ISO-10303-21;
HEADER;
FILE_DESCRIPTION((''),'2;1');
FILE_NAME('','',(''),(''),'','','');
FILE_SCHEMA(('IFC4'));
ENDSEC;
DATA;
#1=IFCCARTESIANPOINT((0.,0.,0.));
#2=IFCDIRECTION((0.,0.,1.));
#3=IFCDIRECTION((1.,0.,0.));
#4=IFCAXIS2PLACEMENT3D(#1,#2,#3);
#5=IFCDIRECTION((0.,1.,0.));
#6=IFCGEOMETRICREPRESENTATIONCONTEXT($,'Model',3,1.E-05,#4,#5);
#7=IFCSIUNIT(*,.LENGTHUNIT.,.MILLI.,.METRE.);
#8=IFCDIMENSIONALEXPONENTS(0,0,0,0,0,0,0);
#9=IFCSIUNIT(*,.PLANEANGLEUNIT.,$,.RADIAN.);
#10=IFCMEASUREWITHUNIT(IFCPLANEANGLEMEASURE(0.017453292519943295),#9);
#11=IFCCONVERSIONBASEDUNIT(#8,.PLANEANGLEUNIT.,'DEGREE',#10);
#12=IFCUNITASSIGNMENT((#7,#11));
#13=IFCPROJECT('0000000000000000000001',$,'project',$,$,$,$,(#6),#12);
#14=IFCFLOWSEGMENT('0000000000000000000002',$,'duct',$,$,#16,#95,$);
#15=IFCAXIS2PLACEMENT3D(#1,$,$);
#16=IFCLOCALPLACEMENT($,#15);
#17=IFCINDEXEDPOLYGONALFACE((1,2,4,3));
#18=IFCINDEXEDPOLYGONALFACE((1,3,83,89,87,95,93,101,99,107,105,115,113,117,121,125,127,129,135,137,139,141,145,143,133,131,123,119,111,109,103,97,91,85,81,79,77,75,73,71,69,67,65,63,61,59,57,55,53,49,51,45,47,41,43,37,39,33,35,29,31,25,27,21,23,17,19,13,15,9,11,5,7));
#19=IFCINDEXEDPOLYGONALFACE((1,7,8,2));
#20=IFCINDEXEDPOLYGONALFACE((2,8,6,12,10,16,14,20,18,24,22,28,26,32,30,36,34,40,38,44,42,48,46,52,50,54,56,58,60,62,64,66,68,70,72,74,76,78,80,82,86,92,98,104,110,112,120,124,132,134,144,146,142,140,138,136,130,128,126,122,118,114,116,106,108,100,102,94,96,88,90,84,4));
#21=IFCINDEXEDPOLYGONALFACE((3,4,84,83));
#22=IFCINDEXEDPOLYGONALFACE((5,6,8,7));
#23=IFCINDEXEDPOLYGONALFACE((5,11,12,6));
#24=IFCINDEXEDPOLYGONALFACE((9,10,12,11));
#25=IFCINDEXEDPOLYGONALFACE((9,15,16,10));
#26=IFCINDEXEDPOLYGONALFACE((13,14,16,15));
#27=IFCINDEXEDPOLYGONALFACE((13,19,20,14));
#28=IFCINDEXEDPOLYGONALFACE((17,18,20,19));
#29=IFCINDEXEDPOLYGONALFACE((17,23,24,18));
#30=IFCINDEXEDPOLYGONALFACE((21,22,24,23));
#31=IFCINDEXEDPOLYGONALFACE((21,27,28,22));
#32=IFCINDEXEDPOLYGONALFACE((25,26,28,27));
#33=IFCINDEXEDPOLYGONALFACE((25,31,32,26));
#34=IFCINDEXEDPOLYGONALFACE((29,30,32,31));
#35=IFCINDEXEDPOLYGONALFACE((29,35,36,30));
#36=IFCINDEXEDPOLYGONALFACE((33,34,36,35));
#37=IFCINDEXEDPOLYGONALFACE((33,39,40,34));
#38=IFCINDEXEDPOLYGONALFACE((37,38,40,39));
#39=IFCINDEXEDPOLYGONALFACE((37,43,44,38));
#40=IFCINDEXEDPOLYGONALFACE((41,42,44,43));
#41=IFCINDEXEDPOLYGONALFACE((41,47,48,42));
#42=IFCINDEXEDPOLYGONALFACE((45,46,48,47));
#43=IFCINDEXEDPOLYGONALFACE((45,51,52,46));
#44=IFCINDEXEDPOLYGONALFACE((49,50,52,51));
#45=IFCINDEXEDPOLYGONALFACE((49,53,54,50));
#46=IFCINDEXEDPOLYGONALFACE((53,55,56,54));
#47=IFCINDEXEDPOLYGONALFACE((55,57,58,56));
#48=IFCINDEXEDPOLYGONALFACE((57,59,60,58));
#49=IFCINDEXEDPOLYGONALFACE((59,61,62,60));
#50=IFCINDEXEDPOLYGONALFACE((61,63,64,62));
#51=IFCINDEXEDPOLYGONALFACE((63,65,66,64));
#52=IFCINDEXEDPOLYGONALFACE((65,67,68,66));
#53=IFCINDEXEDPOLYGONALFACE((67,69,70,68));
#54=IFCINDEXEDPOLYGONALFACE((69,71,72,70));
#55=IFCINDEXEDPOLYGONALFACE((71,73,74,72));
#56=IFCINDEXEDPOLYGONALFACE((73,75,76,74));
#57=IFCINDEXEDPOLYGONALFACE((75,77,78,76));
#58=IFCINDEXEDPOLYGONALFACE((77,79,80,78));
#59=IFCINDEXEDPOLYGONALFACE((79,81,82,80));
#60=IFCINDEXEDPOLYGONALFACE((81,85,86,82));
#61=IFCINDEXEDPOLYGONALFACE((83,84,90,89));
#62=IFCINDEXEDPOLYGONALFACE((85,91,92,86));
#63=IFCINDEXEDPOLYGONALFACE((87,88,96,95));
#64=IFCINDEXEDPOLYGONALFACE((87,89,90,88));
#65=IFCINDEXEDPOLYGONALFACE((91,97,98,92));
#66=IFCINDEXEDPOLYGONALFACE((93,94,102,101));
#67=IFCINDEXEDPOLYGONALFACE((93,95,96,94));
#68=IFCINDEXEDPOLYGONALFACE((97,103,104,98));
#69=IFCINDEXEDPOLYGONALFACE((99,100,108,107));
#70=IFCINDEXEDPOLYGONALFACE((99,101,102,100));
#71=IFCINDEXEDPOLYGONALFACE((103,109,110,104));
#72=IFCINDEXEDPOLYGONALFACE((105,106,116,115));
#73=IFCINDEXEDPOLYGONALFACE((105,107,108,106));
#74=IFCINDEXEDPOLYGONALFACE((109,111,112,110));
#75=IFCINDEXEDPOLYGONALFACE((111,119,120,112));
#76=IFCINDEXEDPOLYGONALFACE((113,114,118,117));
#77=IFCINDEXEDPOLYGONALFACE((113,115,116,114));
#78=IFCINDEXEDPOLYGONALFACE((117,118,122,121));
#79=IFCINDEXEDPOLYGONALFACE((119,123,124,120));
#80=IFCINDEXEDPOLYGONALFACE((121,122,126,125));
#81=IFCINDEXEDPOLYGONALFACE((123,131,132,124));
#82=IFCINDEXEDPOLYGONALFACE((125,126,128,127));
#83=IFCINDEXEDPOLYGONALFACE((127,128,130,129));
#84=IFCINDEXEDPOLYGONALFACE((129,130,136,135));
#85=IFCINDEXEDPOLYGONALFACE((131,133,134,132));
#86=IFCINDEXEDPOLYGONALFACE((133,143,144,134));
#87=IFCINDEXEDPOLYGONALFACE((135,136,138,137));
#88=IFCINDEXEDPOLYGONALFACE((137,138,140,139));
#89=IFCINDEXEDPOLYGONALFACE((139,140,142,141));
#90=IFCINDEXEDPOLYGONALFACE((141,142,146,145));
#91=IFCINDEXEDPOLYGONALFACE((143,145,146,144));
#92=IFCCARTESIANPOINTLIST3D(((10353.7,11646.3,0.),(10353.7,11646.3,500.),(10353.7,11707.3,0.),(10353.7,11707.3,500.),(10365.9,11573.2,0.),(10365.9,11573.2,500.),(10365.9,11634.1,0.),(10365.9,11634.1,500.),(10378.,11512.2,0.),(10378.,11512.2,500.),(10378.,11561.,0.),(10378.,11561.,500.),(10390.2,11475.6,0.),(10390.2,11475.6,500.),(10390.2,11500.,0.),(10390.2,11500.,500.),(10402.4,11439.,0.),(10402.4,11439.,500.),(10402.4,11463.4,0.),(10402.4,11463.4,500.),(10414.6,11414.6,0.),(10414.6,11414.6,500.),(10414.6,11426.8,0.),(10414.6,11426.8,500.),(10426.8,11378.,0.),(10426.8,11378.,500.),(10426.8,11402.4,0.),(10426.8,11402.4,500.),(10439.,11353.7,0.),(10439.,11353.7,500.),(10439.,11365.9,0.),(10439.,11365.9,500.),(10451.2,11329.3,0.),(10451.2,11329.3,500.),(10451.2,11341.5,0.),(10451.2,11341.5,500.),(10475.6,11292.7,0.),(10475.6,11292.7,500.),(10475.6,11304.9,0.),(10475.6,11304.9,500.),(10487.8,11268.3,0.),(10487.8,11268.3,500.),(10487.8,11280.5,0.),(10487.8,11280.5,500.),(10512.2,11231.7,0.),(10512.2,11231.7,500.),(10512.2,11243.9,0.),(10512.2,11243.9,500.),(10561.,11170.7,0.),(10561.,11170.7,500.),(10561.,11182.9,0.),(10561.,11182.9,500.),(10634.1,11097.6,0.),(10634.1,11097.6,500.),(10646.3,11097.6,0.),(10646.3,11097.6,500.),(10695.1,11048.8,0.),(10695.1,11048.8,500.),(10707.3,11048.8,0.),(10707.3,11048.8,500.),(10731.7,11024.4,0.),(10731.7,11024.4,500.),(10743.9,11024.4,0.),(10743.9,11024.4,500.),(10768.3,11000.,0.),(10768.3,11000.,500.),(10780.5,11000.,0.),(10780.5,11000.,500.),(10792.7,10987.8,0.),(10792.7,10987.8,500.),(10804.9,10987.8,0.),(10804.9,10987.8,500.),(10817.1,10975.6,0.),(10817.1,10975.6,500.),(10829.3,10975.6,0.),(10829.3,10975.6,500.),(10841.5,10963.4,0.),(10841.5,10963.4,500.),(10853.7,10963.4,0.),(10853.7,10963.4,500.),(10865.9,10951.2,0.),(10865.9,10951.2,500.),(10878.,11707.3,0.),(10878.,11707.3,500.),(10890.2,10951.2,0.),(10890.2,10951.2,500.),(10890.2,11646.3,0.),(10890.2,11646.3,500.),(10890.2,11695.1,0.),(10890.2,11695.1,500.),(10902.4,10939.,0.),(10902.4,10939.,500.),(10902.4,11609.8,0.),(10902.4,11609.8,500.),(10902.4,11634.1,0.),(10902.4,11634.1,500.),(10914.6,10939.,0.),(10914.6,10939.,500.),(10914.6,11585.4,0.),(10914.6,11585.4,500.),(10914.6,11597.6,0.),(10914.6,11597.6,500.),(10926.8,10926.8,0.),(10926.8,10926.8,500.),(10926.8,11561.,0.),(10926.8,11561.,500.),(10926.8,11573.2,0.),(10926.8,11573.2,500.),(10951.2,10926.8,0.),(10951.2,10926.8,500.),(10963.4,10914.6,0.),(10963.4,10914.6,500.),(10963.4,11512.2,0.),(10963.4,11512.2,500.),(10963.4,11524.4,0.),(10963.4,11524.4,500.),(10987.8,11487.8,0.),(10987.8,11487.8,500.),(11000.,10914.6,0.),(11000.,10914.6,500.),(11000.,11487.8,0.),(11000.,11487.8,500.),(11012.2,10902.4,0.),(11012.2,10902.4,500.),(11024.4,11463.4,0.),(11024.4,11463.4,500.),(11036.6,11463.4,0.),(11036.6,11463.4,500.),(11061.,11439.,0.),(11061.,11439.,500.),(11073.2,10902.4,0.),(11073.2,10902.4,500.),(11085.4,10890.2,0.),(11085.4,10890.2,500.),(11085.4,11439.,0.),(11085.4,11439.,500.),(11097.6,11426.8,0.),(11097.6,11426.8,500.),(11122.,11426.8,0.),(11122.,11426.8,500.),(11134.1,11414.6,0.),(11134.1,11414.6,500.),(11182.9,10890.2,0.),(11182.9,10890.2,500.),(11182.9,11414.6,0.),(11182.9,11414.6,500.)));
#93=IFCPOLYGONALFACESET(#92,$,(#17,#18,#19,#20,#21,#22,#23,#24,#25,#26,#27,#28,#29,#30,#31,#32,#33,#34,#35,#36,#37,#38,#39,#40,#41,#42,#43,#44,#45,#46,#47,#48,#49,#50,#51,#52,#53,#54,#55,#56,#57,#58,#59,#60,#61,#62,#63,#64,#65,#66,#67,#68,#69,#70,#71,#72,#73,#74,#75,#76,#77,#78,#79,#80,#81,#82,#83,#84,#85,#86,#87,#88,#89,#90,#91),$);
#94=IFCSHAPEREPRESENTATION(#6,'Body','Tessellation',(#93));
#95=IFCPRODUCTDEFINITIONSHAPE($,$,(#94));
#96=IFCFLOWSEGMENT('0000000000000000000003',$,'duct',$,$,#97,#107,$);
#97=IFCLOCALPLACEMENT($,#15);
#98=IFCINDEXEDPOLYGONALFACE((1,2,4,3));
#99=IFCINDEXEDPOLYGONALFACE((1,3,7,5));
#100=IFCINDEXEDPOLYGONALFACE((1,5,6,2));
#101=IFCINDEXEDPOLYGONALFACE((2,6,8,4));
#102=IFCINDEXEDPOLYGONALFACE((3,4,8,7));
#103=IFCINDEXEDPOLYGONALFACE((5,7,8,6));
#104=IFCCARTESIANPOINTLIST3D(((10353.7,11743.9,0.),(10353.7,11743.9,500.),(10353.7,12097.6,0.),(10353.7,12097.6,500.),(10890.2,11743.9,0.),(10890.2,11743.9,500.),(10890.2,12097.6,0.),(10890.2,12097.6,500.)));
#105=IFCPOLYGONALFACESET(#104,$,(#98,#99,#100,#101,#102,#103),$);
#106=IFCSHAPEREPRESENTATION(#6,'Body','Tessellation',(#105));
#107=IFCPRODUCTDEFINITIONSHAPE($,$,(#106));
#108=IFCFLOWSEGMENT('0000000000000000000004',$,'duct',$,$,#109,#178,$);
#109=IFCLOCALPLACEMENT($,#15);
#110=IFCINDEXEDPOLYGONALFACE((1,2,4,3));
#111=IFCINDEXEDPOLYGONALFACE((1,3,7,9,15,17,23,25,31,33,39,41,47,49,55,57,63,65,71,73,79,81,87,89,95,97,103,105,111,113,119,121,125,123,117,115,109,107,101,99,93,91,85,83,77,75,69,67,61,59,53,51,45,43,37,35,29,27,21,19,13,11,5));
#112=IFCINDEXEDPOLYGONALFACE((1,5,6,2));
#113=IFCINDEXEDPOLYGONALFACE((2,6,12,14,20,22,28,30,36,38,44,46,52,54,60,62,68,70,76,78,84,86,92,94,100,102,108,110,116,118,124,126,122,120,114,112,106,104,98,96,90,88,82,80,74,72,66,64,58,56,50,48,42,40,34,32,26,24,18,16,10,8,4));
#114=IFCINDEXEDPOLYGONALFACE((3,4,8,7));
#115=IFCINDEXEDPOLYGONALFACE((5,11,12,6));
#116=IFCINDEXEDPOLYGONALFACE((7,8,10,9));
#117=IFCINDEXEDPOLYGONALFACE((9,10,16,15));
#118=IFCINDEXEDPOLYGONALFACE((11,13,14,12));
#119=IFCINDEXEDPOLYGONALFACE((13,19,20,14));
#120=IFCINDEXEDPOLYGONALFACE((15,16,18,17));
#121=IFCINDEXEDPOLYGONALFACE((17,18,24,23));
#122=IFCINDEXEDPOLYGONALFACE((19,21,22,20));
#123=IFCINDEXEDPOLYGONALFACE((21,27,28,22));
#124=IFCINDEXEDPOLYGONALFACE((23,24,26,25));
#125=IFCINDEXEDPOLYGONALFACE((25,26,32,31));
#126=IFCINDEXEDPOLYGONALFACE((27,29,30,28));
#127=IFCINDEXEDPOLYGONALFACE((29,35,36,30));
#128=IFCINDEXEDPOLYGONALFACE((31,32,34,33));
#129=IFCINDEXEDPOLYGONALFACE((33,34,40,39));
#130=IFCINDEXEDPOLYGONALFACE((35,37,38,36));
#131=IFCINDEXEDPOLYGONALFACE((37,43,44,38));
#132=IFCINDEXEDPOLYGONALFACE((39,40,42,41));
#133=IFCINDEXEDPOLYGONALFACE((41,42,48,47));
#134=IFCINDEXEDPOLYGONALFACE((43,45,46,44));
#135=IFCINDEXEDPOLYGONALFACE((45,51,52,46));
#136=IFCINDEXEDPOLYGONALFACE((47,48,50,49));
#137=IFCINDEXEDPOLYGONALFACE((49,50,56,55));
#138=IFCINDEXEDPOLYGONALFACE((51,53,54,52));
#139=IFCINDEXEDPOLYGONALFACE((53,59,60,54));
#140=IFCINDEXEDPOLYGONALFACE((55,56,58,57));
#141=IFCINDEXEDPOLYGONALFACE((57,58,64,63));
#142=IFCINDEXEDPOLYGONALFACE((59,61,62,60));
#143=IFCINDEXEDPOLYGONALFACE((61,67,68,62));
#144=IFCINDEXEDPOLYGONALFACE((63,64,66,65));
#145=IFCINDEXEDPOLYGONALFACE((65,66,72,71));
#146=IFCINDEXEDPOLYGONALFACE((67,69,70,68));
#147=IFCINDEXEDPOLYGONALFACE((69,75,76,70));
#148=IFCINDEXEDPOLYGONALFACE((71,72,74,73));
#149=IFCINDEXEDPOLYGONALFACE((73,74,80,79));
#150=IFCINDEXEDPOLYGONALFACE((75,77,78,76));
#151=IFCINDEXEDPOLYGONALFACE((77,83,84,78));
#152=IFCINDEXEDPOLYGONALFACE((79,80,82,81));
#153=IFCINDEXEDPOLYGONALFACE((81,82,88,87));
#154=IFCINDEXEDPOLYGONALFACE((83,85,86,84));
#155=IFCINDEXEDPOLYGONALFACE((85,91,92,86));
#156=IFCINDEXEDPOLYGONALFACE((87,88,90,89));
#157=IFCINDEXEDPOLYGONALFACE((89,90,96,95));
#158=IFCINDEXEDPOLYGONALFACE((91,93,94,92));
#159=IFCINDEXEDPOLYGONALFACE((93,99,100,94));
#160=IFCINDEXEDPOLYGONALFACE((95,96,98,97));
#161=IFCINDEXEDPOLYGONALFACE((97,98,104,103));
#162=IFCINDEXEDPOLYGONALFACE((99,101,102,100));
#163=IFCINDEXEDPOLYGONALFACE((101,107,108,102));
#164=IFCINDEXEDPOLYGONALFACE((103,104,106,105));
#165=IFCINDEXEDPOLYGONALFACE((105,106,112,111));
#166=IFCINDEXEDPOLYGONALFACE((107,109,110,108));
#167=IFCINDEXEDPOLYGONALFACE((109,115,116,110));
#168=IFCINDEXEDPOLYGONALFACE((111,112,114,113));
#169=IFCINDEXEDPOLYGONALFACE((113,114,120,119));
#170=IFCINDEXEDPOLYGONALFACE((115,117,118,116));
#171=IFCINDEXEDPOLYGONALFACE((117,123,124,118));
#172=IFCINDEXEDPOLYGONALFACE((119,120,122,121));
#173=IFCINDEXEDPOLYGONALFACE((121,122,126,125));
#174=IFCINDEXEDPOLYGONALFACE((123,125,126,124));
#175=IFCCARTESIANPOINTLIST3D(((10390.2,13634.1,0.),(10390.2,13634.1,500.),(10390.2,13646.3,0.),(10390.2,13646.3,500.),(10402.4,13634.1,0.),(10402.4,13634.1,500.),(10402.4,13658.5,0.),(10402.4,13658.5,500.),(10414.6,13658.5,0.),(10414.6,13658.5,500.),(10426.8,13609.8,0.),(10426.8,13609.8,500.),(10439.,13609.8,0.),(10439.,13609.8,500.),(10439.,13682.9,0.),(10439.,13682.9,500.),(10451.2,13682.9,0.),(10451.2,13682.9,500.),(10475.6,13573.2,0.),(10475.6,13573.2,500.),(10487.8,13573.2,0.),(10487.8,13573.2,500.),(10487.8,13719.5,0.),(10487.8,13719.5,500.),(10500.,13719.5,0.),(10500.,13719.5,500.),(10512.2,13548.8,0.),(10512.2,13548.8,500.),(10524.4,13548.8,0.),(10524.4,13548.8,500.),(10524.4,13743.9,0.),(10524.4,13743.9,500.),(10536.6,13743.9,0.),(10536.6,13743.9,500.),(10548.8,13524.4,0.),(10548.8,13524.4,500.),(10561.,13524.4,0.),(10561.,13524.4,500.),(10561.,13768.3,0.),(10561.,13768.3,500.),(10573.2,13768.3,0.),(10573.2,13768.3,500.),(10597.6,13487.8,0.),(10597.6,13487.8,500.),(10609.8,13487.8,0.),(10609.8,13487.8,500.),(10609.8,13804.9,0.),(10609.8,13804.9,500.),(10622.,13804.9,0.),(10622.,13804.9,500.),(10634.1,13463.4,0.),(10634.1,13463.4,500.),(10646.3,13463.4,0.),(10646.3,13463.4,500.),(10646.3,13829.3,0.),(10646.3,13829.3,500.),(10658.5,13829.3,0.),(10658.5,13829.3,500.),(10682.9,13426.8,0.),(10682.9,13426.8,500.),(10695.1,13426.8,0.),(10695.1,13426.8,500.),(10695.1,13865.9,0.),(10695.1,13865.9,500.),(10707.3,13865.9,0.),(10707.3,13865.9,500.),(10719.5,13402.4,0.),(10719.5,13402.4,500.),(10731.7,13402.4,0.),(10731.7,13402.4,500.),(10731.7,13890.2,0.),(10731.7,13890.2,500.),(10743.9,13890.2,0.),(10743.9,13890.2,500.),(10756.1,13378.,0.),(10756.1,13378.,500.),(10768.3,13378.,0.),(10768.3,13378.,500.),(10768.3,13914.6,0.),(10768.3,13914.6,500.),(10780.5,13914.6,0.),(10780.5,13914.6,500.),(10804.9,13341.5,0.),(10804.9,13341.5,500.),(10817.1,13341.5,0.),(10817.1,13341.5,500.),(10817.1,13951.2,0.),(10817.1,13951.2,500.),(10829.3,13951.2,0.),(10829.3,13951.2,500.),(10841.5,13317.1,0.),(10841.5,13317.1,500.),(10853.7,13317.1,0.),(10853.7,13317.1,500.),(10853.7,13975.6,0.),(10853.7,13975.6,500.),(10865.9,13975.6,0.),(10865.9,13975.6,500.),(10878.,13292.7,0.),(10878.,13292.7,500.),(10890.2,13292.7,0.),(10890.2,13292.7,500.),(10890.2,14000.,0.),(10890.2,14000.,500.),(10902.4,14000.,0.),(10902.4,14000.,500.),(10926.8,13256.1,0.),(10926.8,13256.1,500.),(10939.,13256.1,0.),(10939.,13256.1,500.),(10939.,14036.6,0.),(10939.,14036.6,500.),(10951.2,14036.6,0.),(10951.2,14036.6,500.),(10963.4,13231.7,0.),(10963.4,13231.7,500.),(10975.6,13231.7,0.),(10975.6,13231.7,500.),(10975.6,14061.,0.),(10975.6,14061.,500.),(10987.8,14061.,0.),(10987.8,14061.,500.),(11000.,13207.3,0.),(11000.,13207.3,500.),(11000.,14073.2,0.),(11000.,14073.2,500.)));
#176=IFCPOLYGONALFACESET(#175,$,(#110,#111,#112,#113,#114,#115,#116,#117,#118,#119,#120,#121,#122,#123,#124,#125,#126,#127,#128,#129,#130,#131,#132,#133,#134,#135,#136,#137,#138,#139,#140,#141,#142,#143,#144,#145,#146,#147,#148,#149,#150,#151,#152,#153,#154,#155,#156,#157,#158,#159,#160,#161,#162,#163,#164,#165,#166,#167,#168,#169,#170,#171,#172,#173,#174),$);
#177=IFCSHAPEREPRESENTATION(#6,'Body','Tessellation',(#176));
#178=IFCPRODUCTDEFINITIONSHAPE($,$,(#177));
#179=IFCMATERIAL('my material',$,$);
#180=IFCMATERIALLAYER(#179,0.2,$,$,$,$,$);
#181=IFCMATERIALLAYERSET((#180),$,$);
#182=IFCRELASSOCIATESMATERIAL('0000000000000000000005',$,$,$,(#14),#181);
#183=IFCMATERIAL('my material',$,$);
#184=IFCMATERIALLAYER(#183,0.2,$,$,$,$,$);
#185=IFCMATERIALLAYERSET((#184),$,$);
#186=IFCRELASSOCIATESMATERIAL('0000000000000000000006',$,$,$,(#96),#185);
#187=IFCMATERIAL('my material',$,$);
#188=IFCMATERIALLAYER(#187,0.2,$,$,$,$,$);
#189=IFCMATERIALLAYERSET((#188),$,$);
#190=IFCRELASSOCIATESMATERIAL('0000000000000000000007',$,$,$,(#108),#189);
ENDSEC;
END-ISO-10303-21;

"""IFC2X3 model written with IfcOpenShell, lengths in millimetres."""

from ifc_helpers import new_model, entity, si_unit, converted_unit, direction, origin_with_axes, place, context, project, polyline, outline, extrude, material, layer, layer_set, layer_usage, element, save


model = new_model("IFC2X3")

# Units and contexts
model_context = context("Model", 3, precision=1e-05, world=origin_with_axes(), true_north=direction((0.0, 1.0, 0.0)))
ifc_project = project(units=[si_unit("LENGTHUNIT", "METRE", prefix="MILLI"), converted_unit("PLANEANGLEUNIT", "DEGREE", entity("IfcPlaneAngleMeasure", 0.017453292519943295), si_unit("PLANEANGLEUNIT", "RADIAN"), dimensions=[0, 0, 0, 0, 0, 0, 0])], contexts=[model_context])

# Flow segments
ifc_material_1 = material(Name="my material")
ifc_layer_1 = layer(ifc_material_1, 0.2)
ifc_layer_set_1 = layer_set([ifc_layer_1])
ifc_layer_usage_1 = layer_usage(ifc_layer_set_1, "AXIS2", "POSITIVE", -0.1)
flow_segment_1_placement = place(None, origin_with_axes())
element("IfcFlowSegment", 1, at=flow_segment_1_placement, material=ifc_layer_usage_1, Name="duct", context=model_context, shape_type="SweptSolid", body=[
    extrude(outline(polyline([(10353.7, 11646.3), (10365.9, 11634.1), (10365.9, 11573.2), (10378.0, 11561.0), (10378.0, 11512.2), (10390.2, 11500.0), (10390.2, 11475.6), (10402.4, 11463.4), (10402.4, 11439.0), (10414.6, 11426.8), (10414.6, 11414.6), (10426.8, 11402.4), (10426.8, 11378.0), (10439.0, 11365.9), (10439.0, 11353.7), (10451.2, 11341.5), (10451.2, 11329.3), (10475.6, 11304.9), (10475.6, 11292.7), (10487.8, 11280.5), (10487.8, 11268.3), (10512.2, 11243.9), (10512.2, 11231.7), (10561.0, 11182.9), (10561.0, 11170.7), (10634.1, 11097.6), (10646.3, 11097.6), (10695.1, 11048.8), (10707.3, 11048.8), (10731.7, 11024.4), (10743.9, 11024.4), (10768.3, 11000.0), (10780.5, 11000.0), (10792.7, 10987.8), (10804.9, 10987.8), (10817.1, 10975.6), (10829.3, 10975.6), (10841.5, 10963.4), (10853.7, 10963.4), (10865.9, 10951.2), (10890.2, 10951.2), (10902.4, 10939.0), (10914.6, 10939.0), (10926.8, 10926.8), (10951.2, 10926.8), (10963.4, 10914.6), (11000.0, 10914.6), (11012.2, 10902.4), (11073.2, 10902.4), (11085.4, 10890.2), (11182.9, 10890.2), (11182.9, 11414.6), (11134.1, 11414.6), (11122.0, 11426.8), (11097.6, 11426.8), (11085.4, 11439.0), (11061.0, 11439.0), (11036.6, 11463.4), (11024.4, 11463.4), (11000.0, 11487.8), (10987.8, 11487.8), (10963.4, 11512.2), (10963.4, 11524.4), (10926.8, 11561.0), (10926.8, 11573.2), (10914.6, 11585.4), (10914.6, 11597.6), (10902.4, 11609.8), (10902.4, 11634.1), (10890.2, 11646.3), (10890.2, 11695.1), (10878.0, 11707.3), (10353.7, 11707.3), (10353.7, 11646.3)])), origin_with_axes(), (0.0, 0.0, 1.0), 500.0),
])
ifc_material_2 = material(Name="my material")
ifc_layer_2 = layer(ifc_material_2, 0.2)
ifc_layer_set_2 = layer_set([ifc_layer_2])
ifc_layer_usage_2 = layer_usage(ifc_layer_set_2, "AXIS2", "POSITIVE", -0.1)
flow_segment_2_placement = place(None, origin_with_axes())
element("IfcFlowSegment", 2, at=flow_segment_2_placement, material=ifc_layer_usage_2, Name="duct", context=model_context, shape_type="SweptSolid", body=[
    extrude(outline(polyline([(10353.7, 11743.9), (10890.2, 11743.9), (10890.2, 12097.6), (10353.7, 12097.6), (10353.7, 11743.9)])), origin_with_axes(), (0.0, 0.0, 1.0), 500.0),
])
ifc_material_3 = material(Name="my material")
ifc_layer_3 = layer(ifc_material_3, 0.2)
ifc_layer_set_3 = layer_set([ifc_layer_3])
ifc_layer_usage_3 = layer_usage(ifc_layer_set_3, "AXIS2", "POSITIVE", -0.1)
flow_segment_3_placement = place(None, origin_with_axes())
element("IfcFlowSegment", 3, at=flow_segment_3_placement, material=ifc_layer_usage_3, Name="duct", context=model_context, shape_type="SweptSolid", body=[
    extrude(outline(polyline([(10390.2, 13634.1), (10402.4, 13634.1), (10426.8, 13609.8), (10439.0, 13609.8), (10475.6, 13573.2), (10487.8, 13573.2), (10512.2, 13548.8), (10524.4, 13548.8), (10548.8, 13524.4), (10561.0, 13524.4), (10597.6, 13487.8), (10609.8, 13487.8), (10634.1, 13463.4), (10646.3, 13463.4), (10682.9, 13426.8), (10695.1, 13426.8), (10719.5, 13402.4), (10731.7, 13402.4), (10756.1, 13378.0), (10768.3, 13378.0), (10804.9, 13341.5), (10817.1, 13341.5), (10841.5, 13317.1), (10853.7, 13317.1), (10878.0, 13292.7), (10890.2, 13292.7), (10926.8, 13256.1), (10939.0, 13256.1), (10963.4, 13231.7), (10975.6, 13231.7), (11000.0, 13207.3), (11000.0, 14073.2), (10987.8, 14061.0), (10975.6, 14061.0), (10951.2, 14036.6), (10939.0, 14036.6), (10902.4, 14000.0), (10890.2, 14000.0), (10865.9, 13975.6), (10853.7, 13975.6), (10829.3, 13951.2), (10817.1, 13951.2), (10780.5, 13914.6), (10768.3, 13914.6), (10743.9, 13890.2), (10731.7, 13890.2), (10707.3, 13865.9), (10695.1, 13865.9), (10658.5, 13829.3), (10646.3, 13829.3), (10622.0, 13804.9), (10609.8, 13804.9), (10573.2, 13768.3), (10561.0, 13768.3), (10536.6, 13743.9), (10524.4, 13743.9), (10500.0, 13719.5), (10487.8, 13719.5), (10451.2, 13682.9), (10439.0, 13682.9), (10414.6, 13658.5), (10402.4, 13658.5), (10390.2, 13646.3), (10390.2, 13634.1)])), origin_with_axes(), (0.0, 0.0, 1.0), 500.0),
])

save(model, "model.ifc")
